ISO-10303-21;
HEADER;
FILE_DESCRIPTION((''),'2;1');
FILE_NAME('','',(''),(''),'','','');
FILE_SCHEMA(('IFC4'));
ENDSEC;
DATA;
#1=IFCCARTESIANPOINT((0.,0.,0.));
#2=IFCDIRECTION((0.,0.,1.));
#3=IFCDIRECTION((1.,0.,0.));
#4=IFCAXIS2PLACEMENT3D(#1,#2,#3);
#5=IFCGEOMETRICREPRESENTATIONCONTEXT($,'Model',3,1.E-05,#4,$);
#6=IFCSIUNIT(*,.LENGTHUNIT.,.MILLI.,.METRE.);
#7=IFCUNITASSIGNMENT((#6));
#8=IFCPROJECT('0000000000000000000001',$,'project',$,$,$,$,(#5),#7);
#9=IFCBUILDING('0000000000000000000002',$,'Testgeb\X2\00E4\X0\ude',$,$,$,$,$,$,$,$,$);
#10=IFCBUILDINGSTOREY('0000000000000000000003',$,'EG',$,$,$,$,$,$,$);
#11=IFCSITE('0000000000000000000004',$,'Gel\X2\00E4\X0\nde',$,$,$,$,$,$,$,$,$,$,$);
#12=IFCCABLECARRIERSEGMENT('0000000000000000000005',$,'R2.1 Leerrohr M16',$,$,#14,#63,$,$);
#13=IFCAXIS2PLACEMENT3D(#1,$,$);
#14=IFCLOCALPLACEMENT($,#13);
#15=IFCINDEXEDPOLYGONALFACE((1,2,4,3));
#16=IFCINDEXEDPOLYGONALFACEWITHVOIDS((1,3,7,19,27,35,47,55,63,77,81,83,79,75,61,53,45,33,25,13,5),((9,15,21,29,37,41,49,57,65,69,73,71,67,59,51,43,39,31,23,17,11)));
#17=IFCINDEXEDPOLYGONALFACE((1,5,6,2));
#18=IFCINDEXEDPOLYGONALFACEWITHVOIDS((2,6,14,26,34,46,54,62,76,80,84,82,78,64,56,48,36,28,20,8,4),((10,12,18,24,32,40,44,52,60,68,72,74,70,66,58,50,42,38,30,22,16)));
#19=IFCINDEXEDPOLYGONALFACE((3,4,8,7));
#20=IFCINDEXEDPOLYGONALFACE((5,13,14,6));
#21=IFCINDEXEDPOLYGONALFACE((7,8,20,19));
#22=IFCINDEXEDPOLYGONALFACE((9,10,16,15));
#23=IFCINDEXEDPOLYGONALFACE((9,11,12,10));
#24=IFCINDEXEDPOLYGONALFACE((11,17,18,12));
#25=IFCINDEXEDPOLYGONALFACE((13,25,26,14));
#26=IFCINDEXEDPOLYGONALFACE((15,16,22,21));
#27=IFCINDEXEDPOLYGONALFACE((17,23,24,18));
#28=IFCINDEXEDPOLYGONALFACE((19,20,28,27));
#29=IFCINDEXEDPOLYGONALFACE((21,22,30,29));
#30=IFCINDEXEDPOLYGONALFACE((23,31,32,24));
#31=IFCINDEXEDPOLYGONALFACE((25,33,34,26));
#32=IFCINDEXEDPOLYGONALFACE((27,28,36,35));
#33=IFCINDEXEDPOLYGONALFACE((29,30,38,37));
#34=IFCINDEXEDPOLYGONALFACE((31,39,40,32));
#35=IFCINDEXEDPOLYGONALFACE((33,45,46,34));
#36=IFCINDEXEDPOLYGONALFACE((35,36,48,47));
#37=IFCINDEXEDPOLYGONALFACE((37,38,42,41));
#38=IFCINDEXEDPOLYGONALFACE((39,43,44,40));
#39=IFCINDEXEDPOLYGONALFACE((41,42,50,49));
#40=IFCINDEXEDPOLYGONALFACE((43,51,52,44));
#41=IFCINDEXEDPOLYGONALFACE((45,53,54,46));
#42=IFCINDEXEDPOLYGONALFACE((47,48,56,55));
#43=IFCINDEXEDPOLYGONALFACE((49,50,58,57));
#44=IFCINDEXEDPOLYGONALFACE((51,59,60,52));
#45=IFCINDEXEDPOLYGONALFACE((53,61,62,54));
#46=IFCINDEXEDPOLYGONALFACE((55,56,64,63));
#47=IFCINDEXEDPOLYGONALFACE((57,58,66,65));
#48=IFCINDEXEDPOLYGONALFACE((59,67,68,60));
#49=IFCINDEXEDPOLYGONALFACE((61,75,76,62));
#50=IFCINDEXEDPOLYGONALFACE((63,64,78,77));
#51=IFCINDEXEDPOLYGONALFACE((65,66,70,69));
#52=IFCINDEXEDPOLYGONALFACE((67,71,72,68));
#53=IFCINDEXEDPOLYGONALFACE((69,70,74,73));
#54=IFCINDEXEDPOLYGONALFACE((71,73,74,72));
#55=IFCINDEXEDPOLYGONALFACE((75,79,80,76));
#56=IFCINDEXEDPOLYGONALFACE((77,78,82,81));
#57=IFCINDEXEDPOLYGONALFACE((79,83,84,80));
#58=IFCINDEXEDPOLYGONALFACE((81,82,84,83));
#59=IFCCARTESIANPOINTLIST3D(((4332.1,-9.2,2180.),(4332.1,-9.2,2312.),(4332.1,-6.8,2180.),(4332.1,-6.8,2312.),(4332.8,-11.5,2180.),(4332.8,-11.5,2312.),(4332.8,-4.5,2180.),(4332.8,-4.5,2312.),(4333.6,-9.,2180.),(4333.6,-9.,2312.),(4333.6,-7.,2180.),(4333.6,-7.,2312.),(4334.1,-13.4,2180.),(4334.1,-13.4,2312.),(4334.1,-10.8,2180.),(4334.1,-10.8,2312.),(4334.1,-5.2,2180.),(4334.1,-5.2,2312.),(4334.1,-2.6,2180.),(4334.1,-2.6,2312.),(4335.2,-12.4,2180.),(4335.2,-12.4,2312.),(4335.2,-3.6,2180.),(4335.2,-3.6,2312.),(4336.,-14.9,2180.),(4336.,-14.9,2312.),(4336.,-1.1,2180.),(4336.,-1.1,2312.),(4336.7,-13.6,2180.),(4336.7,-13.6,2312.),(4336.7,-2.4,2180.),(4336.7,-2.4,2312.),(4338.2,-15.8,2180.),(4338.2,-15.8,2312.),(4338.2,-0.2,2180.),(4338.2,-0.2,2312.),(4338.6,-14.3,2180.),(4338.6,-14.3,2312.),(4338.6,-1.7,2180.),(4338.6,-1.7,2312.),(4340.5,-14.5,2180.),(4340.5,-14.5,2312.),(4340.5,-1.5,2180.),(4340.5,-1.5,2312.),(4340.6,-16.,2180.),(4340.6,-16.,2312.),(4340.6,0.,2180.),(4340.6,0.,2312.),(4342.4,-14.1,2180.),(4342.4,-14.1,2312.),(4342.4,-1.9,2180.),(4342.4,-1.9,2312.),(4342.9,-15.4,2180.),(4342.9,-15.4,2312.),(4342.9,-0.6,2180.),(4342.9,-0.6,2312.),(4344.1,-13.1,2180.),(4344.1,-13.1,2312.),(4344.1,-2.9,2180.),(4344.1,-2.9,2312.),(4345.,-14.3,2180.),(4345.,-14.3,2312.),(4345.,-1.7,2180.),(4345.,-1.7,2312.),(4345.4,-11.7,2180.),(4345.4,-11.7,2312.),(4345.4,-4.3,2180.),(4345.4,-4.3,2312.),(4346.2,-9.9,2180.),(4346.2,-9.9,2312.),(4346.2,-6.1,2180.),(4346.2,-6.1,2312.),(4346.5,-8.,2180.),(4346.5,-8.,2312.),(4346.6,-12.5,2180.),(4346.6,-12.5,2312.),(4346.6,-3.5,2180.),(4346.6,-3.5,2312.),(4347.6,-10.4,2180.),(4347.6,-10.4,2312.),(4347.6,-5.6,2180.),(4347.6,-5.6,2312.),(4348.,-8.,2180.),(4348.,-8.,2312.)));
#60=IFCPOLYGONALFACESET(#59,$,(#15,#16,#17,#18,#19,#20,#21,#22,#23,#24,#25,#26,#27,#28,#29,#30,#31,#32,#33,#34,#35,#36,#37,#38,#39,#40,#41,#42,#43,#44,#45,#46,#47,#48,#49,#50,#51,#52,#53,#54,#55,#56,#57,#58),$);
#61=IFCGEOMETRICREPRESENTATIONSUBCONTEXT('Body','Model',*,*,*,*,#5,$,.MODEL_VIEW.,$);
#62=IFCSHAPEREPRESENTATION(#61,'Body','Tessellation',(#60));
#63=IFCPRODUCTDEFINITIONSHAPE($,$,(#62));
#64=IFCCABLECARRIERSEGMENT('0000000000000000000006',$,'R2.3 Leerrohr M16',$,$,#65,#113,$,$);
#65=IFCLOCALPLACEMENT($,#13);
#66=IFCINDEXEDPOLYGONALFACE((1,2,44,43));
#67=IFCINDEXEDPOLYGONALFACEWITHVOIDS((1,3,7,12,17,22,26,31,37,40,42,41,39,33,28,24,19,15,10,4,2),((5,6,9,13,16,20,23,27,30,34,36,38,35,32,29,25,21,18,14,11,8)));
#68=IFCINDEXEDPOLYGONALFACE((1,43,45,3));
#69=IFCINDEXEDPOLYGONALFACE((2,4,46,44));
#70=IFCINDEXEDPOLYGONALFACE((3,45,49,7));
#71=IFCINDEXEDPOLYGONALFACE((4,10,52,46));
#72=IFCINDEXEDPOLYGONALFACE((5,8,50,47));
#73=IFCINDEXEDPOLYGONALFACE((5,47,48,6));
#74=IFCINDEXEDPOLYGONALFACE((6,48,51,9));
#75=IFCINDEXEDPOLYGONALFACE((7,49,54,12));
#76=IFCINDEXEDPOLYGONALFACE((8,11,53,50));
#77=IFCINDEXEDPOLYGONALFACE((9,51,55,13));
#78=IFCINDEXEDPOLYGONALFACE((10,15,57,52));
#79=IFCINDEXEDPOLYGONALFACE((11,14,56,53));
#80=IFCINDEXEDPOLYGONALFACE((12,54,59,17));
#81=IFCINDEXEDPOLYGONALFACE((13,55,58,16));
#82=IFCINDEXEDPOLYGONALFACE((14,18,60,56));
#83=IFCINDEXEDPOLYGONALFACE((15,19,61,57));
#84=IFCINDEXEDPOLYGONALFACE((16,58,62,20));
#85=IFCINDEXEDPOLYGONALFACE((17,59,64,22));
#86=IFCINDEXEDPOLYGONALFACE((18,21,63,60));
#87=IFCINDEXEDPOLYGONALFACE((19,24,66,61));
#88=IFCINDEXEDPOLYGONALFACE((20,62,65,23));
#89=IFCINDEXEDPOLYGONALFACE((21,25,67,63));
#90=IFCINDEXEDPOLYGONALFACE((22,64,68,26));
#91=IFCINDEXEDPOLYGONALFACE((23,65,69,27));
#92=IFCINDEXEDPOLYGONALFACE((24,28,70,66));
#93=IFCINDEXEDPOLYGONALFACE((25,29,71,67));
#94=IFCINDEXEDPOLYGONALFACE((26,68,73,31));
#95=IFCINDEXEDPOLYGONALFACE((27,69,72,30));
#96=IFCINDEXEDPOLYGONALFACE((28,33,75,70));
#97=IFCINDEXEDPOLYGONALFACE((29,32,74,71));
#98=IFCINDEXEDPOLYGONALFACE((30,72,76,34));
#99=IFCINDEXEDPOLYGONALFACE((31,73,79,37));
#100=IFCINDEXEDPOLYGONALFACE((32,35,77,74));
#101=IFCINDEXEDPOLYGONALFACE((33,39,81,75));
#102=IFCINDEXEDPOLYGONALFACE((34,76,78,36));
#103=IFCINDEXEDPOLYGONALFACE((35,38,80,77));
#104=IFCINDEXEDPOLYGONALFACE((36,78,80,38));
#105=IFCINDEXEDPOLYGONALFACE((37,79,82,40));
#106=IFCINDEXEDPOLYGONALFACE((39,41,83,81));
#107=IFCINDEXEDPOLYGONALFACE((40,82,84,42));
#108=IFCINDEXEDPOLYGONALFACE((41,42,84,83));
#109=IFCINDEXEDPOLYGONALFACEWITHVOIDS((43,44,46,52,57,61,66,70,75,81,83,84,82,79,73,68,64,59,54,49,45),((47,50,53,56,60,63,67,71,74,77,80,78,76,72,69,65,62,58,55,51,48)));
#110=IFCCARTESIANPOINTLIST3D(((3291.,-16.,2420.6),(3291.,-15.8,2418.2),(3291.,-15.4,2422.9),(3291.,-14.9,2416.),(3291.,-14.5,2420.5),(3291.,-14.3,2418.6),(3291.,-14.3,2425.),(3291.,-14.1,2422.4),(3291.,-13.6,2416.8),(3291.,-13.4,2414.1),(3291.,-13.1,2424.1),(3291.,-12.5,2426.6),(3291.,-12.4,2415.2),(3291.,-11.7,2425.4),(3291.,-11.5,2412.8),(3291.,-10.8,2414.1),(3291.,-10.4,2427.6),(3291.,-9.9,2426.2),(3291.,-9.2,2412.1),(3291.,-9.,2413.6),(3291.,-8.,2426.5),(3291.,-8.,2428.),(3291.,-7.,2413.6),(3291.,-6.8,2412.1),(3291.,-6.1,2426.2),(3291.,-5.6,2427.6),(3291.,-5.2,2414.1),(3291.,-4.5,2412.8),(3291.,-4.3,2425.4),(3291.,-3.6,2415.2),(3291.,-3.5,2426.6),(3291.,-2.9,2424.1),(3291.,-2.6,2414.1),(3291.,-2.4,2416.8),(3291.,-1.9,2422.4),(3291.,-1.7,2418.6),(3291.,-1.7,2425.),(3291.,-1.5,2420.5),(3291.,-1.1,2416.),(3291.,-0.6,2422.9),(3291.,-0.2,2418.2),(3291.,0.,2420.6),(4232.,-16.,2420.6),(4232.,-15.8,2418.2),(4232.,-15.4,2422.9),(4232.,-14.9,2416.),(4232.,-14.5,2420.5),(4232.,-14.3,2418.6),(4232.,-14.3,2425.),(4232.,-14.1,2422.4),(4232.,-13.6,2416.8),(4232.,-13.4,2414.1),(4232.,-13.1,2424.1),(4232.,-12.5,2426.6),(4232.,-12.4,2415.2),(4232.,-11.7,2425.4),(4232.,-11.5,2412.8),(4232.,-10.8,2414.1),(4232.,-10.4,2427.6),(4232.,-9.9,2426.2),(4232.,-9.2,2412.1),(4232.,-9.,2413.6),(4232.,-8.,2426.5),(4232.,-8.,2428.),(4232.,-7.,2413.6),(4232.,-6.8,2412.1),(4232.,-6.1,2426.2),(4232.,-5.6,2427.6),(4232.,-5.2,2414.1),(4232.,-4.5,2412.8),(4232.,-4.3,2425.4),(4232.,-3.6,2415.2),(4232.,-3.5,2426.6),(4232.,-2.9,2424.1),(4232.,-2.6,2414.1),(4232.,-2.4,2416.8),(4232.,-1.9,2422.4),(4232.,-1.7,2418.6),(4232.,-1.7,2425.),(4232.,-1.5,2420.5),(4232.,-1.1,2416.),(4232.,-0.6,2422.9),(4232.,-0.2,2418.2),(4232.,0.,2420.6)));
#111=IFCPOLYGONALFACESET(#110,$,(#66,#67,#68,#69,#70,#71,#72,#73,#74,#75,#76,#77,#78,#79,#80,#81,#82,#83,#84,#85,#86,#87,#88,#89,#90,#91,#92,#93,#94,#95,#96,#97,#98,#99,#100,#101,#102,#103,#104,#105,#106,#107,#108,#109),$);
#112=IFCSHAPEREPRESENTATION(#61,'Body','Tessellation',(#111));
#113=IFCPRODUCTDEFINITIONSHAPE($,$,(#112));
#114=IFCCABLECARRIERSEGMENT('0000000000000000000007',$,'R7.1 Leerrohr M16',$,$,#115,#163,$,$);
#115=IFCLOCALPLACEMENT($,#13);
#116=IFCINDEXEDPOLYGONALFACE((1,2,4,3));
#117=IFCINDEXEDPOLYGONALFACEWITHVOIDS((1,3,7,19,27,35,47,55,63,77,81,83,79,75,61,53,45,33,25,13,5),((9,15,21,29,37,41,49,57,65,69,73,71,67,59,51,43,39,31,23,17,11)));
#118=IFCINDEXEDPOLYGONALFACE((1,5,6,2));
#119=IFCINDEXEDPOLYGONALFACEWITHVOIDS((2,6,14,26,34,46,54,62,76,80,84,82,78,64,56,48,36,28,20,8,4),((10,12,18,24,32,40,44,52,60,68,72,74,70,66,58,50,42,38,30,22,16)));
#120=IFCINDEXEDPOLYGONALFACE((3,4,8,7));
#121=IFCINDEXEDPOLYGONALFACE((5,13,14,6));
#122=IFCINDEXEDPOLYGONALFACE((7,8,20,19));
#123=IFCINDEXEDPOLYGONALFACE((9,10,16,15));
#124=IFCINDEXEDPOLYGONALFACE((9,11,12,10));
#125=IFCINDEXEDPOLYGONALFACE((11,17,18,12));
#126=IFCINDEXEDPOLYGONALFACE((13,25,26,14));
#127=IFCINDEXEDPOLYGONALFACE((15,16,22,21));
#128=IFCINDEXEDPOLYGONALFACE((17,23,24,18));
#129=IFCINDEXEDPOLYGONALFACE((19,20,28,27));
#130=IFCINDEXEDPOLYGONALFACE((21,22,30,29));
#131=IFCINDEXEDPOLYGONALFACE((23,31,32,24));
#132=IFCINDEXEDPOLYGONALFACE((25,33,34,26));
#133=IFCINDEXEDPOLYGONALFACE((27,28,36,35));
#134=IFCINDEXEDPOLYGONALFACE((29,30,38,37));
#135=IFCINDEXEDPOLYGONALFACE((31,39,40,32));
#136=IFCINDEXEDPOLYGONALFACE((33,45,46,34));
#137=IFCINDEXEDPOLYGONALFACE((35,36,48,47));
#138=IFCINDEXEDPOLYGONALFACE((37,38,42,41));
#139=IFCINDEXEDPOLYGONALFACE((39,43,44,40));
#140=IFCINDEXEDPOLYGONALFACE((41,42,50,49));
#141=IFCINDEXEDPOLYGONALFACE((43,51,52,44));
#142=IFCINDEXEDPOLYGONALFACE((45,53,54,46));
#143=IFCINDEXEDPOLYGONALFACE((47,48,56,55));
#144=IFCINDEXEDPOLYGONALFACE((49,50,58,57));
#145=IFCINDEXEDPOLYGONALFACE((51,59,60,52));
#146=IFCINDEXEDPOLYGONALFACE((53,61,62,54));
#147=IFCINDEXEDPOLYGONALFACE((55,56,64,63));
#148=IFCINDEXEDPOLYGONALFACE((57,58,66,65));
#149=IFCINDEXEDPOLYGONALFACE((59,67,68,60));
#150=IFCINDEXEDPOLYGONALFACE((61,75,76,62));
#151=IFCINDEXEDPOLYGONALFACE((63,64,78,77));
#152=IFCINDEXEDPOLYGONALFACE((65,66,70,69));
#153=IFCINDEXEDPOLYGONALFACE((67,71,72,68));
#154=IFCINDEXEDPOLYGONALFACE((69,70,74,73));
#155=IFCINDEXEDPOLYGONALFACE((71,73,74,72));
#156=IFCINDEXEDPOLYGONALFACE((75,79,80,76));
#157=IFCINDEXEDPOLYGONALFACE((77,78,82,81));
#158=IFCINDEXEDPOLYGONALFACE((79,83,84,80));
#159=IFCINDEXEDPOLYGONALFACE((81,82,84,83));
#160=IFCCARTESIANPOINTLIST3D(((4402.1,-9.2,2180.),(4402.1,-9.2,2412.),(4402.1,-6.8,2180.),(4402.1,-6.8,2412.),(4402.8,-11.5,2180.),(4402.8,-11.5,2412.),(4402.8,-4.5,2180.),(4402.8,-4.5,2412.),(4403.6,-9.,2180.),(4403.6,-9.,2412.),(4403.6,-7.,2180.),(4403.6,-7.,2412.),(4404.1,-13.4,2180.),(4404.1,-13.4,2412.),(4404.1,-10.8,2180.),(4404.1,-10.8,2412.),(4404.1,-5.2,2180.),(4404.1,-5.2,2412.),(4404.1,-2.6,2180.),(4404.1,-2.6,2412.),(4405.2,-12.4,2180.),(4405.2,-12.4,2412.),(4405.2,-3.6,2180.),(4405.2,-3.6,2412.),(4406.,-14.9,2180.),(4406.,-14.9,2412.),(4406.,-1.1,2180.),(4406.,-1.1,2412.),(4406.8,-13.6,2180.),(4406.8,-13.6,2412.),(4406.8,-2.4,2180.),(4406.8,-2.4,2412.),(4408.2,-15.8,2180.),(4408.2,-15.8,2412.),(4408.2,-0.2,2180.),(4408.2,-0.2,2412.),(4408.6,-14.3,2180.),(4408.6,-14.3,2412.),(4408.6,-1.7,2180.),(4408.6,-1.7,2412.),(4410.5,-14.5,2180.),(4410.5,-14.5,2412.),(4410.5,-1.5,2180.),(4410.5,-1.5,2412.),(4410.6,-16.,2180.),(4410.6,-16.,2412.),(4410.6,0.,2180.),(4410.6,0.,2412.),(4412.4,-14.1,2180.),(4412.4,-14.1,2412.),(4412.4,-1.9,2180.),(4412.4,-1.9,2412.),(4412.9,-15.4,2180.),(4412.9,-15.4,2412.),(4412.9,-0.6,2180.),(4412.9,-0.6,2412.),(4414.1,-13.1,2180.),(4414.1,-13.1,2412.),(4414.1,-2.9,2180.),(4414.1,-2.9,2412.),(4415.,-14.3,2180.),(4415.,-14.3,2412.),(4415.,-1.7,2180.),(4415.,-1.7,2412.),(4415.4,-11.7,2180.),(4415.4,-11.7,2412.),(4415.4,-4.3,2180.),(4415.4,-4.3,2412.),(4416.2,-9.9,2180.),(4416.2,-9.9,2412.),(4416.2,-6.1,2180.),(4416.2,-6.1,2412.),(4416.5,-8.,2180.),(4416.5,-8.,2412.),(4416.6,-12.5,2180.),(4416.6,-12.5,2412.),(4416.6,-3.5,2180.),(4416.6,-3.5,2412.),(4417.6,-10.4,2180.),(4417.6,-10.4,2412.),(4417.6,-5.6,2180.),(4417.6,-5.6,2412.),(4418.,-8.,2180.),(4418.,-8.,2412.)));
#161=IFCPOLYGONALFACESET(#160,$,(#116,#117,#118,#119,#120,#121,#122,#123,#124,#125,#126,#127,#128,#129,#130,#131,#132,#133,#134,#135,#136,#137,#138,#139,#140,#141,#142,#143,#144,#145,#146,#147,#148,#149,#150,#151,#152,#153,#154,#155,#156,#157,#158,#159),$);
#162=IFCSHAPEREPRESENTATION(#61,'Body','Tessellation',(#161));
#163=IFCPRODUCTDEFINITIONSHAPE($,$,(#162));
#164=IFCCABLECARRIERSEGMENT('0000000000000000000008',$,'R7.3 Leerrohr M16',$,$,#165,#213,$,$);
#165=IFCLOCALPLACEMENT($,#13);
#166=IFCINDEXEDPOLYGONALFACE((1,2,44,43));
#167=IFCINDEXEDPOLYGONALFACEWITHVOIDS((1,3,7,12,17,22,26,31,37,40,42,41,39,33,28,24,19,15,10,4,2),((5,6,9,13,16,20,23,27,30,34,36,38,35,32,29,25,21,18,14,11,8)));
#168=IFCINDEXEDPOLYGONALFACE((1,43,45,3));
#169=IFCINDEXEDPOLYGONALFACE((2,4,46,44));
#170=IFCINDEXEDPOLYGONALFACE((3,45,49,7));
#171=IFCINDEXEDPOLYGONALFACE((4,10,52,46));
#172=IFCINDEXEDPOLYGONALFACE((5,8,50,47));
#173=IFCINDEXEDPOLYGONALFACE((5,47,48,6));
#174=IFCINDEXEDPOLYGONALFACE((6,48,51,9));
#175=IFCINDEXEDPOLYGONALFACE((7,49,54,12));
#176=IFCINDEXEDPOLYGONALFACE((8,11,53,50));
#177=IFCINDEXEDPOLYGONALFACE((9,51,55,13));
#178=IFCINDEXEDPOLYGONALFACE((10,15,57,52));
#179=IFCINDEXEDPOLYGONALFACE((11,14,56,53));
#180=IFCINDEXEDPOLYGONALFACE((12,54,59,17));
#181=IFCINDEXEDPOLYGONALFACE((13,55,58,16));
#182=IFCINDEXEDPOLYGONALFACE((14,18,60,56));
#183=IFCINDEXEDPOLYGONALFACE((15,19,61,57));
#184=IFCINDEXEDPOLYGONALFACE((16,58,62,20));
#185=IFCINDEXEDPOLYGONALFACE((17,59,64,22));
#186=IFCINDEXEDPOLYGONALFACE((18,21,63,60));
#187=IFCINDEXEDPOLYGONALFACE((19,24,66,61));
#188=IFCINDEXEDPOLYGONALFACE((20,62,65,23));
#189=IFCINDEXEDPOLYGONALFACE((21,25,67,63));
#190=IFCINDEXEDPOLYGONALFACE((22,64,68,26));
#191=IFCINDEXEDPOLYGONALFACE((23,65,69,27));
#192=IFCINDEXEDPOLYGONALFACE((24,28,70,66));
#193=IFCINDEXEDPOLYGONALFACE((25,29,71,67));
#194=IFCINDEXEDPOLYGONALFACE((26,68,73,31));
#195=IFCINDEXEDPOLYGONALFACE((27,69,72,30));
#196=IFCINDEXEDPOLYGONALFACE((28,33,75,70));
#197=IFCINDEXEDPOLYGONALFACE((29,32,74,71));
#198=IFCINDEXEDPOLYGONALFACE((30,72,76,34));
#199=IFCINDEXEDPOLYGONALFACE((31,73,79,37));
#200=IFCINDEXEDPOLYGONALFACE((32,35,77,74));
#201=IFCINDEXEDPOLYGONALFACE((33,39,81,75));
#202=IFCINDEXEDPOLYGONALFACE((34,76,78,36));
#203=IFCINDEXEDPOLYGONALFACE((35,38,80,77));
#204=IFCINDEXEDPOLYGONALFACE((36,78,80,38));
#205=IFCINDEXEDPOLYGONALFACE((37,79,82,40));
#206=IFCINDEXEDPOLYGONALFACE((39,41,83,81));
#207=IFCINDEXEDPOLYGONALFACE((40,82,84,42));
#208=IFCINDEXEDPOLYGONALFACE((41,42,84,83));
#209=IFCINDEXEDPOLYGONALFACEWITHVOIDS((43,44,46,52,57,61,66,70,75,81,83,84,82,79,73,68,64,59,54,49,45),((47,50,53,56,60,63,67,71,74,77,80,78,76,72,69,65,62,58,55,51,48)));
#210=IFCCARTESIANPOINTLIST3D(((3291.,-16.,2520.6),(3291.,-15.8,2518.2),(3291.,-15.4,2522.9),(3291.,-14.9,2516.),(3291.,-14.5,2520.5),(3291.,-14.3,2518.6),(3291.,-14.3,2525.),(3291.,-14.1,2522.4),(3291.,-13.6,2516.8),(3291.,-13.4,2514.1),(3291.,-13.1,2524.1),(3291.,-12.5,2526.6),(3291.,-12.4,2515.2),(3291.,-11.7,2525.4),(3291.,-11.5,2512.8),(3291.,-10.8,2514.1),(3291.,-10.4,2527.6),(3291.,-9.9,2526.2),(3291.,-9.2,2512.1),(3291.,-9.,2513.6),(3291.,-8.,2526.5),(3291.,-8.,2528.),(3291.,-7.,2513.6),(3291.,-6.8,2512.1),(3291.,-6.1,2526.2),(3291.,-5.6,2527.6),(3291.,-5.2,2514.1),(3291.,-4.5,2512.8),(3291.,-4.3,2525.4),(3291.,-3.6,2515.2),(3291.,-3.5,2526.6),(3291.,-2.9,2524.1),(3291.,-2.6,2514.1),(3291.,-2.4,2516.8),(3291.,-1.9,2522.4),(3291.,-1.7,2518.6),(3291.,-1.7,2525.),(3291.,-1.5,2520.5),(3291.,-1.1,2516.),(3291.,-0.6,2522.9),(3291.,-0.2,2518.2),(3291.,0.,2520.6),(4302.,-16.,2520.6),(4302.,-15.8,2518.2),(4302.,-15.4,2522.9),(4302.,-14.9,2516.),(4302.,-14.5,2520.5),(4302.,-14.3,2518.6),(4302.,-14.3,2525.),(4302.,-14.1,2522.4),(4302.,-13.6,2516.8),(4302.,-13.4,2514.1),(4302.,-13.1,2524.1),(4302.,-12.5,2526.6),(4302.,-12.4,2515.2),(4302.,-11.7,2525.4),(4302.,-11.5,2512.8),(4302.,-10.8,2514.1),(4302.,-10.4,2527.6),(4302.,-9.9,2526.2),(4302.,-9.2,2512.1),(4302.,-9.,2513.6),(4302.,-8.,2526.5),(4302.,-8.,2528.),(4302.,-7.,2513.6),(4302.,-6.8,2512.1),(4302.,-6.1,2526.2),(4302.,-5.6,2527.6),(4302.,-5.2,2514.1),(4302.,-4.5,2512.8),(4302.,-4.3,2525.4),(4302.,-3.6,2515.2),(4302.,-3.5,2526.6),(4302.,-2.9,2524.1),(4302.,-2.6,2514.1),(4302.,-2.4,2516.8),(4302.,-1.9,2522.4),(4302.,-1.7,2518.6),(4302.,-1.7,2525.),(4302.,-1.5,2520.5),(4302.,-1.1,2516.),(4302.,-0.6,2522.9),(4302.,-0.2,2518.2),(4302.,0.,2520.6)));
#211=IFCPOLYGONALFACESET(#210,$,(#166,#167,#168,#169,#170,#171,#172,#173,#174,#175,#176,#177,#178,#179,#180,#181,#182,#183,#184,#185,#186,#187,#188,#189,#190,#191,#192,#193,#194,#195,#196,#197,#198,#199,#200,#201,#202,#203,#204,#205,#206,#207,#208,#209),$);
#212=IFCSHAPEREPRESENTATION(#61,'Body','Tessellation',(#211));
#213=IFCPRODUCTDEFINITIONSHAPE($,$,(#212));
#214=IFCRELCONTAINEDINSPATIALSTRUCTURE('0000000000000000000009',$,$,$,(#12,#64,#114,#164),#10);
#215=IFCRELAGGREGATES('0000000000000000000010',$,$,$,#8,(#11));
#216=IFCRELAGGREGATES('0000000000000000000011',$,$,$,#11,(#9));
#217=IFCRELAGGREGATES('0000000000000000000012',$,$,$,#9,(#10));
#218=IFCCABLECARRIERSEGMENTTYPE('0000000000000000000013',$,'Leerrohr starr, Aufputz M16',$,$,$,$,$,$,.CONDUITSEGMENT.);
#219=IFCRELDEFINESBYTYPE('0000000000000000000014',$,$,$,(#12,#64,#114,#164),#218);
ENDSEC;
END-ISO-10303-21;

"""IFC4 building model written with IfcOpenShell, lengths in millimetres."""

from ifc_helpers import new_model, si_unit, frame, origin_with_axes, place, context, subcontext, project, spatial, hollow_circle, extrude, type_object, element, save


model = new_model("IFC4")

# Units and contexts
model_context = context("Model", 3, precision=1e-05, world=origin_with_axes())
body_context = subcontext(model_context, "Body", "Model", "MODEL_VIEW")
ifc_project = project(units=[si_unit("LENGTHUNIT", "METRE", prefix="MILLI")], contexts=[model_context])

# Site, building, storey
site = spatial("IfcSite", under=ifc_project, Name="Gelände")
building = spatial("IfcBuilding", under=site, Name="Testgebäude")
storey = spatial("IfcBuildingStorey", under=building, Name="EG")

# Cable carrier segments
cable_carrier_segment_type_1 = type_object("IfcCableCarrierSegmentType", Name="Leerrohr starr, Aufputz M16", PredefinedType="CONDUITSEGMENT")
cable_carrier_segment_1_placement = place(None, frame((4340.0, -8.0, 2180.0), z_axis=(0.0, 0.0, 1.0), x_axis=(1.0, 0.0, 0.0)))
element("IfcCableCarrierSegment", 1, at=cable_carrier_segment_1_placement, inside=storey, type_object=cable_carrier_segment_type_1, Name="R2.1 Leerrohr M16", context=body_context, shape_type="SweptSolid", body=[
    extrude(hollow_circle(Radius=8.0, WallThickness=1.5), None, (0.0, 0.0, 1.0), 132.0),
])
cable_carrier_segment_2_placement = place(None, frame((4232.0, -8.0, 2420.0), z_axis=(-1.0, 0.0, 0.0), x_axis=(0.0, 0.0, 1.0)))
element("IfcCableCarrierSegment", 2, at=cable_carrier_segment_2_placement, inside=storey, type_object=cable_carrier_segment_type_1, Name="R2.3 Leerrohr M16", context=body_context, shape_type="SweptSolid", body=[
    extrude(hollow_circle(Radius=8.0, WallThickness=1.5), None, (0.0, 0.0, 1.0), 941.0),
])
cable_carrier_segment_3_placement = place(None, frame((4410.0, -8.0, 2180.0), z_axis=(0.0, 0.0, 1.0), x_axis=(1.0, 0.0, 0.0)))
element("IfcCableCarrierSegment", 3, at=cable_carrier_segment_3_placement, inside=storey, type_object=cable_carrier_segment_type_1, Name="R7.1 Leerrohr M16", context=body_context, shape_type="SweptSolid", body=[
    extrude(hollow_circle(Radius=8.0, WallThickness=1.5), None, (0.0, 0.0, 1.0), 232.0),
])
cable_carrier_segment_4_placement = place(None, frame((4302.0, -8.0, 2520.0), z_axis=(-1.0, 0.0, 0.0), x_axis=(0.0, 0.0, 1.0)))
element("IfcCableCarrierSegment", 4, at=cable_carrier_segment_4_placement, inside=storey, type_object=cable_carrier_segment_type_1, Name="R7.3 Leerrohr M16", context=body_context, shape_type="SweptSolid", body=[
    extrude(hollow_circle(Radius=8.0, WallThickness=1.5), None, (0.0, 0.0, 1.0), 1011.0),
])

save(model, "model.ifc")
